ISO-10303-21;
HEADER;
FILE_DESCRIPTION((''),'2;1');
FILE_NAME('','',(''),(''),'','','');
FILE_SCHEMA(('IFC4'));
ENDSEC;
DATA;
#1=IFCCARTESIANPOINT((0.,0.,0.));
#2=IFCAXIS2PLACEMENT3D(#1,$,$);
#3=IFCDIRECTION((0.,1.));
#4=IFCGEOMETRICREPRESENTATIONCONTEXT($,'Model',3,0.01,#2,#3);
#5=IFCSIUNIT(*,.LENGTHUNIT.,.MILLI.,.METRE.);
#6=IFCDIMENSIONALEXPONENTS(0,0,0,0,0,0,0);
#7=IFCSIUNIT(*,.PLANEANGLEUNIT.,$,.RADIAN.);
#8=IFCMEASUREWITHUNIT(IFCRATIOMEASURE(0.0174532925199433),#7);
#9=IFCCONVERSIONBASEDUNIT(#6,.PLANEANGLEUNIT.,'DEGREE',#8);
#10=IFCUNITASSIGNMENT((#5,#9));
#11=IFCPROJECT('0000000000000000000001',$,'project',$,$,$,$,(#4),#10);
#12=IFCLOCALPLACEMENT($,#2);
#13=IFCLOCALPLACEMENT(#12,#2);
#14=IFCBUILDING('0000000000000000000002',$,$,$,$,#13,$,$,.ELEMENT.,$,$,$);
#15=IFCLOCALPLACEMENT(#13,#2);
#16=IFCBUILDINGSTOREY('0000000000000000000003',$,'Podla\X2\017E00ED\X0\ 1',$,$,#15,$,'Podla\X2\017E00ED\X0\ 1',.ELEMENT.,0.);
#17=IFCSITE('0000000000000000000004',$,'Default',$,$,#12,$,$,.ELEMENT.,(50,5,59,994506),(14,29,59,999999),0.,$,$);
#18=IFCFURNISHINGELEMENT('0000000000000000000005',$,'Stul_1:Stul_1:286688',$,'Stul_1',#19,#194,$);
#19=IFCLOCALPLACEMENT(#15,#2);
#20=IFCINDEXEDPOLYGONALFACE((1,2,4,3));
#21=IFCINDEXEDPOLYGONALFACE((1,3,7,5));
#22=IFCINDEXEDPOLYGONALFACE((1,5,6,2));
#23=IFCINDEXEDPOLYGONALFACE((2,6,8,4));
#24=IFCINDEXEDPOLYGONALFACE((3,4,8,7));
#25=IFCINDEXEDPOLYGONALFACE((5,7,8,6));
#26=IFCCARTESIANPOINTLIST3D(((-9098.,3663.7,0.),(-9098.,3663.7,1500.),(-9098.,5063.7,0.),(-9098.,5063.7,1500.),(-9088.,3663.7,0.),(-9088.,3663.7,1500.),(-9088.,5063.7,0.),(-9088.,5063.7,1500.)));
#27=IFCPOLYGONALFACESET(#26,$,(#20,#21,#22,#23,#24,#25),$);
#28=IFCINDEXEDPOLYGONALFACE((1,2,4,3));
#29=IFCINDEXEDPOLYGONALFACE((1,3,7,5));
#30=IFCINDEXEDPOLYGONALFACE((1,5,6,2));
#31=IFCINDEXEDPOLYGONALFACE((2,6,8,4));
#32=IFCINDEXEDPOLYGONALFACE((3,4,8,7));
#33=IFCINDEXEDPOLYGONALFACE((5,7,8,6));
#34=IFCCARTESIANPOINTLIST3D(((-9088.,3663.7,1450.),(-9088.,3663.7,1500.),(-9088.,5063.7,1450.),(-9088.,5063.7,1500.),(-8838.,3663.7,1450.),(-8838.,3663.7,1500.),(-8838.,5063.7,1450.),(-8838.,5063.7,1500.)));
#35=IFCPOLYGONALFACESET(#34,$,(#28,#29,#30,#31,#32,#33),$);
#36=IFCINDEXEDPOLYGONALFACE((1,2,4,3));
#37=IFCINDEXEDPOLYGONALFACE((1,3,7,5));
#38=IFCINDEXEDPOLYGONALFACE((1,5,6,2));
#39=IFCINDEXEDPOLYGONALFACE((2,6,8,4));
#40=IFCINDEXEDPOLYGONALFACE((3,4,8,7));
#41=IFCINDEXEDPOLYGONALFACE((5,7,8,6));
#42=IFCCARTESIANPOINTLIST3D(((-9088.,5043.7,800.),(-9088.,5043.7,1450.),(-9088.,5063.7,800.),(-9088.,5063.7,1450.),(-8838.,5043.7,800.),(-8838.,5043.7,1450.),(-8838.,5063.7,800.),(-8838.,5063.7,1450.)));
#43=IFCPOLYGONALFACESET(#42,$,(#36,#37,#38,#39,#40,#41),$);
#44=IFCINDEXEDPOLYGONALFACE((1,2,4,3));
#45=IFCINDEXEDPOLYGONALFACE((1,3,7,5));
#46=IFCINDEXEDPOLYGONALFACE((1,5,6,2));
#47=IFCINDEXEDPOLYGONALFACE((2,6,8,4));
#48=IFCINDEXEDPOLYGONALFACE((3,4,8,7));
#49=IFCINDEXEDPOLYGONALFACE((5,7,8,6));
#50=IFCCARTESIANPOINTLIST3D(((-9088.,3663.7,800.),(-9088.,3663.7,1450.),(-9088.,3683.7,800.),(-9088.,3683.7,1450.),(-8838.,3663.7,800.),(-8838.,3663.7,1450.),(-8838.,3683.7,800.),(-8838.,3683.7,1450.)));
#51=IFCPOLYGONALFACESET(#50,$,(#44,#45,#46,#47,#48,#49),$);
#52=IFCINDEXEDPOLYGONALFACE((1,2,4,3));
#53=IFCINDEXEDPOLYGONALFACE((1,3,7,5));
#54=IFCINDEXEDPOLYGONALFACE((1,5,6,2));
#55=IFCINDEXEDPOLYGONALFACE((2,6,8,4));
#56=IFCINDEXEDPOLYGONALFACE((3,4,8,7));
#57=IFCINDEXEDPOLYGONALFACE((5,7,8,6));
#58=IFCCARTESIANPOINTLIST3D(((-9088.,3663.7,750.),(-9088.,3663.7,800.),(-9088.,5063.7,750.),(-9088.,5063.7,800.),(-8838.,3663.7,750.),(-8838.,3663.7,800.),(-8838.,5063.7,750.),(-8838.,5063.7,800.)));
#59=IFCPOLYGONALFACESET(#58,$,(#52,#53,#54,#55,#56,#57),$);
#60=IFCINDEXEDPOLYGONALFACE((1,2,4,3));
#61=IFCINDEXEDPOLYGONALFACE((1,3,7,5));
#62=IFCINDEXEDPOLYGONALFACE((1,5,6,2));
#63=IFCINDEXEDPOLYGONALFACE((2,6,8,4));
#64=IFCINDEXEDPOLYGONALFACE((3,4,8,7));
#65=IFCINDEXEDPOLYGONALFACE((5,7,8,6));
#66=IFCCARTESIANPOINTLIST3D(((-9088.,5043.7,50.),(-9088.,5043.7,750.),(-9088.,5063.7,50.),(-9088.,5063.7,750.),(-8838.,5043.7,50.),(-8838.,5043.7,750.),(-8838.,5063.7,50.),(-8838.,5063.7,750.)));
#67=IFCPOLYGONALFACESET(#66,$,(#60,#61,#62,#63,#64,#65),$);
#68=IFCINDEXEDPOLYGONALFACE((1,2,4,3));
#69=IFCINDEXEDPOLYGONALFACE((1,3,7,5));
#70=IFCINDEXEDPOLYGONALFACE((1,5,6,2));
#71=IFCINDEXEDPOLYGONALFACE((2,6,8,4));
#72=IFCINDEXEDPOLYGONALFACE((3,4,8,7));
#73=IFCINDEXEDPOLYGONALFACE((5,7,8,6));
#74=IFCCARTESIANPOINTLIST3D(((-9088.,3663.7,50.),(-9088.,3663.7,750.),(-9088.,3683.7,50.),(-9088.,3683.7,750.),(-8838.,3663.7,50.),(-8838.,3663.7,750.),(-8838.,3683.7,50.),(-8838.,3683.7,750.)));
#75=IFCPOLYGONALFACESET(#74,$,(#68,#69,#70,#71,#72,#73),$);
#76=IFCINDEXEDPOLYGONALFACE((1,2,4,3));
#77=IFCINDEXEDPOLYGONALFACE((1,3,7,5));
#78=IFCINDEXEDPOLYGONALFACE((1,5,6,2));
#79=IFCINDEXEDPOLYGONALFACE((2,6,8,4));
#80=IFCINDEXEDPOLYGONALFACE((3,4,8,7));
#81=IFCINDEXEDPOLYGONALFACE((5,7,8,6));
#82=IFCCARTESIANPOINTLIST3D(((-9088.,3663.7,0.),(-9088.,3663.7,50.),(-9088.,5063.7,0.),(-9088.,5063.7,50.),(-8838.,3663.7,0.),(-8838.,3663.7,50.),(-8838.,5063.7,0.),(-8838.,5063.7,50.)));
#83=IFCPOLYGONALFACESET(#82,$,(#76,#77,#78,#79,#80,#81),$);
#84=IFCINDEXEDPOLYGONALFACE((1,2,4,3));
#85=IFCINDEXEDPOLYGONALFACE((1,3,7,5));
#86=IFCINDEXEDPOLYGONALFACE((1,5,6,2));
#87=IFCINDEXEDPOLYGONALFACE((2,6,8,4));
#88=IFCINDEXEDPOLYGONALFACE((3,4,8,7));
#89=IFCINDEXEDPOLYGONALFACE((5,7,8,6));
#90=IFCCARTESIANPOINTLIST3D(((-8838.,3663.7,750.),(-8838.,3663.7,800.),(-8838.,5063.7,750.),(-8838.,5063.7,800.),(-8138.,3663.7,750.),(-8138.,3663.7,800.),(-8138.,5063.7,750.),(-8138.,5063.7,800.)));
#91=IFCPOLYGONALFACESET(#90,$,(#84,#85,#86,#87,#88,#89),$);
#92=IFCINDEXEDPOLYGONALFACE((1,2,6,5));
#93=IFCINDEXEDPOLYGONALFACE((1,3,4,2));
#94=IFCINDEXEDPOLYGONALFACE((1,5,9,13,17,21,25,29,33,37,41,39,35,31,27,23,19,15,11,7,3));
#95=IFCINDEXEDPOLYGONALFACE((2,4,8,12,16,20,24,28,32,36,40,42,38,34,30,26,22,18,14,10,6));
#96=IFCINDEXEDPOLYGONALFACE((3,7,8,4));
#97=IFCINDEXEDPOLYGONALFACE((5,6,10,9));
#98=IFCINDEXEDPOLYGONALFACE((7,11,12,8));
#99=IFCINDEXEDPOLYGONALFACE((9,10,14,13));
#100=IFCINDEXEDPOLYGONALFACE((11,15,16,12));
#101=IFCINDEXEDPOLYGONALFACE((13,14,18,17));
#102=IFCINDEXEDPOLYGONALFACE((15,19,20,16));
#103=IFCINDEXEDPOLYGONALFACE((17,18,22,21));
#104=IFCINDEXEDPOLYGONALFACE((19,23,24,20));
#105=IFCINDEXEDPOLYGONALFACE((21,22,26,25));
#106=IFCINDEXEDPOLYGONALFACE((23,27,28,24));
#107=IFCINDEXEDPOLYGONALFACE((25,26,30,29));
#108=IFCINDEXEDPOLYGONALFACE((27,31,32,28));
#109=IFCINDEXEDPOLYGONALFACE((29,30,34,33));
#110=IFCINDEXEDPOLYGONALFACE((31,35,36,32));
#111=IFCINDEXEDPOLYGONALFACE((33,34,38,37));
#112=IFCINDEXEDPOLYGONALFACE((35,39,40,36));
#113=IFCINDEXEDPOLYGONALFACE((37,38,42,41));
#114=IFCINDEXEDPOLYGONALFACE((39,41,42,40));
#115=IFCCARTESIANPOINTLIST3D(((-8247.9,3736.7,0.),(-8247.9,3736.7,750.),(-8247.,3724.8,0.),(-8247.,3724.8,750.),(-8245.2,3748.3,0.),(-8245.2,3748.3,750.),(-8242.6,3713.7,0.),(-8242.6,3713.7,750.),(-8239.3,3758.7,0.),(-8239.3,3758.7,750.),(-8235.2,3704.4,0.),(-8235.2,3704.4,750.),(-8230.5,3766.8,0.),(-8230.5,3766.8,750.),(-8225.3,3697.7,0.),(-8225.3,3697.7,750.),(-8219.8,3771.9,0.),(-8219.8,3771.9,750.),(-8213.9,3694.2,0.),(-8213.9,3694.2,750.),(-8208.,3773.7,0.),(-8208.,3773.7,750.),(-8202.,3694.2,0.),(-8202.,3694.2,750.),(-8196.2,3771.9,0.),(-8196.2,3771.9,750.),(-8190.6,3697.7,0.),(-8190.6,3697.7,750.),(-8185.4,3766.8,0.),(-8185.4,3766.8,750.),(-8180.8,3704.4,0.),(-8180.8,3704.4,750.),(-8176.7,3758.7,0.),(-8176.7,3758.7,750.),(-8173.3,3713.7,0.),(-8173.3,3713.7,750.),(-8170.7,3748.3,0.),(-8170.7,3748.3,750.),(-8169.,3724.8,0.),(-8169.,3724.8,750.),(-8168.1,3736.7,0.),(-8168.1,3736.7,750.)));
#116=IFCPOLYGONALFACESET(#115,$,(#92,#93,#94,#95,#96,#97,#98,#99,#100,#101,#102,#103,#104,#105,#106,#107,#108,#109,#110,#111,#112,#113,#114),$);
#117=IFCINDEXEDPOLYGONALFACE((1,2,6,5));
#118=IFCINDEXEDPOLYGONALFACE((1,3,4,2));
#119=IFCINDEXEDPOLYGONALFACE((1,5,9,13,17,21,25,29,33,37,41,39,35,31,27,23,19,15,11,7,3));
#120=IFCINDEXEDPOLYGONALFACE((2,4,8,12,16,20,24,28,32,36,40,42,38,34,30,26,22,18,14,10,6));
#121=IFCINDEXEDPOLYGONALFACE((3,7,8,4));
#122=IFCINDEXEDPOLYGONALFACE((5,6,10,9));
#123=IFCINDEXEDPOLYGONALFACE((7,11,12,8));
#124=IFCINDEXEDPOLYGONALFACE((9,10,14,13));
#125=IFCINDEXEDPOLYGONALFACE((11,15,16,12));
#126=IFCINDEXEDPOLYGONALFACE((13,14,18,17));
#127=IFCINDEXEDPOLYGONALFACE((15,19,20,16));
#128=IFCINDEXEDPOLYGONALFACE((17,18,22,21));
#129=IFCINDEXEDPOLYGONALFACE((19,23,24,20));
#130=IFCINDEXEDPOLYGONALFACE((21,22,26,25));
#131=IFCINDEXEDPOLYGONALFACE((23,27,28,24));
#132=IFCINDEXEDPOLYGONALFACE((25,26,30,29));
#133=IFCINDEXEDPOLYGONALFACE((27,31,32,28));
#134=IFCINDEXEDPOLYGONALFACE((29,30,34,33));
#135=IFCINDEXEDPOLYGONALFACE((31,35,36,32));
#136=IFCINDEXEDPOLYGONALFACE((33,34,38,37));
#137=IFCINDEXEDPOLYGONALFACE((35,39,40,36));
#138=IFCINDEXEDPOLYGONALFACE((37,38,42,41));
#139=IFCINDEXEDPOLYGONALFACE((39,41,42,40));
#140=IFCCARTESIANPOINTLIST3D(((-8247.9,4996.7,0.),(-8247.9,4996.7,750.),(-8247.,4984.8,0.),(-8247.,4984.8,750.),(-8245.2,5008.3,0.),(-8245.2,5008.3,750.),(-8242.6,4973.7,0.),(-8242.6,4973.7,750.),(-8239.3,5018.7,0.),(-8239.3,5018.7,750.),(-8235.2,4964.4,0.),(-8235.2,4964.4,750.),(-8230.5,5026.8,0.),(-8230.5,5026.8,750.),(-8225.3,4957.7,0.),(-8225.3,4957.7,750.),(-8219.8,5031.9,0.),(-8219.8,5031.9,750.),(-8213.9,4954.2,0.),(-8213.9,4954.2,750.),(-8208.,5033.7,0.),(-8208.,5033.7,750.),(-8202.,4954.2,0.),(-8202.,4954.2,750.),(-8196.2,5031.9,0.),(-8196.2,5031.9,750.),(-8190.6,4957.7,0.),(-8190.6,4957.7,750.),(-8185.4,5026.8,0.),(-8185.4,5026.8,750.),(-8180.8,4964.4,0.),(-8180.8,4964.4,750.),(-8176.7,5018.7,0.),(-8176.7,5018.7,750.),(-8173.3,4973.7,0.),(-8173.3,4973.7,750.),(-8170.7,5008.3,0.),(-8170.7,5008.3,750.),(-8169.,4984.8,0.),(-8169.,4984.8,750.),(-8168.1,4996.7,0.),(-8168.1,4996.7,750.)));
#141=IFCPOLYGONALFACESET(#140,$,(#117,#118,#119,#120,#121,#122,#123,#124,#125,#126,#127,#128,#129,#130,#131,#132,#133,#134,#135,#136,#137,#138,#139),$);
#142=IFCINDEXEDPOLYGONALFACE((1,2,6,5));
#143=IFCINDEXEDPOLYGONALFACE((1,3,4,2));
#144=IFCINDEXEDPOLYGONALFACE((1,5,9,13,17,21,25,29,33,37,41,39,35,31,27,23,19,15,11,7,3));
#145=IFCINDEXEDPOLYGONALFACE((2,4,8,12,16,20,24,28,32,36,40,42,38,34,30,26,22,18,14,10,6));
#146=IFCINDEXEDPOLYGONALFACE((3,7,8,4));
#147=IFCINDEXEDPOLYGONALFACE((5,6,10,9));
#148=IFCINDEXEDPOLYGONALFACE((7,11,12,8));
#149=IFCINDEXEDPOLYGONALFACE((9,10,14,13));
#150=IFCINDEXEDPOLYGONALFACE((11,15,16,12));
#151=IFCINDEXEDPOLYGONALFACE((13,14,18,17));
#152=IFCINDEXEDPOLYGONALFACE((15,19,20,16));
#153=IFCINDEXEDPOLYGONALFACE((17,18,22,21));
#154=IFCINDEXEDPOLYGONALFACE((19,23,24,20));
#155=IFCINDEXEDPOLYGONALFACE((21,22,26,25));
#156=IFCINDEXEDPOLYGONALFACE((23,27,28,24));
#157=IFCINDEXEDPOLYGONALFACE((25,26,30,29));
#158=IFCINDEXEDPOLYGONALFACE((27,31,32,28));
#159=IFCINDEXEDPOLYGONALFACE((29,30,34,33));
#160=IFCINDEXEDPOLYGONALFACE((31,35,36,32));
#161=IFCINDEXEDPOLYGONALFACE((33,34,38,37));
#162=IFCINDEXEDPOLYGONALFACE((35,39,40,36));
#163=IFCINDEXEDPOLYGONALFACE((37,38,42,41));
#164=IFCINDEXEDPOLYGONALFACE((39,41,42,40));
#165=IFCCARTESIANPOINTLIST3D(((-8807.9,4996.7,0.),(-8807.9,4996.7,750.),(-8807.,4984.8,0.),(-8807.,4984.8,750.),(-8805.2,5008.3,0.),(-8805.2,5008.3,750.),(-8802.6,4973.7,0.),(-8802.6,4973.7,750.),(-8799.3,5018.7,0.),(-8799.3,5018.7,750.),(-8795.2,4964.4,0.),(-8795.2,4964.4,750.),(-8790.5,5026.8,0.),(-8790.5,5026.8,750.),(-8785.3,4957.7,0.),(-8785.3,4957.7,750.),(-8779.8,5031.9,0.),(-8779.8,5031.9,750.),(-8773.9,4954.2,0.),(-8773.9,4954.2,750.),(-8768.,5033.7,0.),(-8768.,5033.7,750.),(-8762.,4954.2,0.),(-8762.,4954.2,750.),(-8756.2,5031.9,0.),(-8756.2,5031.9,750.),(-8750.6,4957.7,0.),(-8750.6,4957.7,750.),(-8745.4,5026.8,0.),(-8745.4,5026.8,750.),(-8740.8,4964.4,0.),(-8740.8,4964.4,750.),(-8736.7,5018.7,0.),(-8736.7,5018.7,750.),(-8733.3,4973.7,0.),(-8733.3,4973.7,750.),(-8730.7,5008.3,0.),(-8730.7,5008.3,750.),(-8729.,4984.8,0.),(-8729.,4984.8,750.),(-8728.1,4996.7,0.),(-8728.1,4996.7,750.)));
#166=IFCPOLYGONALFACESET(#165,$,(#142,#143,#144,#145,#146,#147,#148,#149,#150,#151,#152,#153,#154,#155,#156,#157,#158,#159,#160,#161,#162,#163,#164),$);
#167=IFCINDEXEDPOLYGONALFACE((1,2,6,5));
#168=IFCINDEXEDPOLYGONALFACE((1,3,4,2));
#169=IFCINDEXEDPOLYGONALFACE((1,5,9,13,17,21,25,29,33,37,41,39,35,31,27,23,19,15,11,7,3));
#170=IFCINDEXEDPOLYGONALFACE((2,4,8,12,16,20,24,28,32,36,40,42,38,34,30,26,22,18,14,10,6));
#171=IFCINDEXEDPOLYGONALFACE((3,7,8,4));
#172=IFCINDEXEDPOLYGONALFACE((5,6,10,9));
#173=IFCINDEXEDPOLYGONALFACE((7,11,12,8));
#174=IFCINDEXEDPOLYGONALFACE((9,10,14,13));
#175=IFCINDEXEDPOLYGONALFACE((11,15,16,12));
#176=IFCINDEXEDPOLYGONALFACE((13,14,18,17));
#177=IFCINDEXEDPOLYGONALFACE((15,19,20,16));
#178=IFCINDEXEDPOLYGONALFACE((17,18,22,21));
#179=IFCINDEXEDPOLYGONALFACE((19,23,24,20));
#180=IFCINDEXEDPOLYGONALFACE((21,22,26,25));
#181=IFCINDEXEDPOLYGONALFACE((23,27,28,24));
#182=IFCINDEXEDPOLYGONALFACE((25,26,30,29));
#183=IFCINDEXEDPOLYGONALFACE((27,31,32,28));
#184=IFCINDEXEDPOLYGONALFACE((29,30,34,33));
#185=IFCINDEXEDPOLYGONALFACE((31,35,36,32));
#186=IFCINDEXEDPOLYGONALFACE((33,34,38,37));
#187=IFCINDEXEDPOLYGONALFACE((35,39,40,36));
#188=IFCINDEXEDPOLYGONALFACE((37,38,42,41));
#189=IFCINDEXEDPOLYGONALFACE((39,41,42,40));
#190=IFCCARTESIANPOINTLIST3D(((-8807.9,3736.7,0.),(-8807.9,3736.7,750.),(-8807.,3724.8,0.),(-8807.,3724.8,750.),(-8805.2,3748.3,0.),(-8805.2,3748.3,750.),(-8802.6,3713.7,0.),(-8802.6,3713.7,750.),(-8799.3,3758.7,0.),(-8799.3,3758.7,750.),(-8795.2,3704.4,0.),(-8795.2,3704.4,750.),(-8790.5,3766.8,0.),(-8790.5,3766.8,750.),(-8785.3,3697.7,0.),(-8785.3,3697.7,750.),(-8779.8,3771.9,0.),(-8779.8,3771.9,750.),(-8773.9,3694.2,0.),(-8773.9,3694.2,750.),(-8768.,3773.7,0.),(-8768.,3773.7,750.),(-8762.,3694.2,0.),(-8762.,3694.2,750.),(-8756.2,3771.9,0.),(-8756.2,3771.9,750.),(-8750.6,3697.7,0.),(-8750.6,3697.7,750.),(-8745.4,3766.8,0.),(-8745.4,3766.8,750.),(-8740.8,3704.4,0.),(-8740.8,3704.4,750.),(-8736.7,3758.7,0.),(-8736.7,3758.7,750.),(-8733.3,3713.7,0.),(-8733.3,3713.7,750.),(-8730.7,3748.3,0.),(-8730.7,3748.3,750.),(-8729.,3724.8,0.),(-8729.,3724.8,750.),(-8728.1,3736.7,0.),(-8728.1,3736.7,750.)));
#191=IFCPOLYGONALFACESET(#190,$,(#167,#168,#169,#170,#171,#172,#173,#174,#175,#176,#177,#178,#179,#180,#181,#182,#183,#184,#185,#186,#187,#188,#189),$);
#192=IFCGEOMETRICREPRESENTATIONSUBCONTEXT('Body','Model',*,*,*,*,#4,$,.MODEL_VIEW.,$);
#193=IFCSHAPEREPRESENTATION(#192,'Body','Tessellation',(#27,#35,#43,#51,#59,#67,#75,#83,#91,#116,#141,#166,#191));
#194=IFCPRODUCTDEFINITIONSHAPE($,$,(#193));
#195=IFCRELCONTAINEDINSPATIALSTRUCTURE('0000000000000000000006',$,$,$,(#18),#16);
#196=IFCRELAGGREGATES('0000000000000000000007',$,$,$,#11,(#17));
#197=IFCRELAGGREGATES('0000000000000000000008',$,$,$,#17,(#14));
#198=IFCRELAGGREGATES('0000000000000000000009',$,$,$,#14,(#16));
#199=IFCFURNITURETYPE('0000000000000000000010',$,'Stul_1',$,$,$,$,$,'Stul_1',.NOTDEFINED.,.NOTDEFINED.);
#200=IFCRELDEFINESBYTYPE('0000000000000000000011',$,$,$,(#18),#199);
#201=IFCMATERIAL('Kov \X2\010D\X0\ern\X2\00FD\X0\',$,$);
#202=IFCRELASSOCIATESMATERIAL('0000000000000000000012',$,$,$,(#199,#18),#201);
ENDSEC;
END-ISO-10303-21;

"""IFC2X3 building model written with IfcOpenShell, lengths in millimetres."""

from ifc_helpers import new_model, entity, si_unit, converted_unit, direction, frame, frame_2d, origin, origin_2d_with_axis, place, context, subcontext, project, spatial, rectangle, circle, extrude, source, transform, mapped, material, type_object, type_shapes, element, save


model = new_model("IFC2X3")

# Units and contexts
model_context = context("Model", 3, precision=0.01, world=origin(), true_north=direction((0.0, 1.0)))
body_context = subcontext(model_context, "Body", "Model", "MODEL_VIEW")
ifc_project = project(units=[si_unit("LENGTHUNIT", "METRE", prefix="MILLI"), converted_unit("PLANEANGLEUNIT", "DEGREE", entity("IfcRatioMeasure", 0.0174532925199433), si_unit("PLANEANGLEUNIT", "RADIAN"), dimensions=[0, 0, 0, 0, 0, 0, 0])], contexts=[model_context])

# Site, building, storey
site_placement = place(None, origin())
site = spatial("IfcSite", under=ifc_project, at=site_placement, Name="Default", CompositionType="ELEMENT", RefLatitude=(50, 5, 59, 994506), RefLongitude=(14, 29, 59, 999999), RefElevation=0.0)
building_placement = place(site_placement, origin())
building = spatial("IfcBuilding", under=site, at=building_placement, CompositionType="ELEMENT")
storey_placement = place(building_placement, origin())
storey = spatial("IfcBuildingStorey", under=building, at=storey_placement, Name="Podlaží 1", LongName="Podlaží 1", CompositionType="ELEMENT", Elevation=0.0)

# Furnishing element
ifc_material_1 = material(Name="Kov černý")
furniture_type = type_object("IfcFurnitureType", Name="Stul_1", ElementType="Stul_1", material=ifc_material_1)
shared_shape_1 = source(origin(), body_context, "Body", "SweptSolid", [
    extrude(rectangle(XDim=1400.0, YDim=10.0, at=origin_2d_with_axis()), frame((0.0, 605.0, 0.0), z_axis=(0.0, 0.0, 1.0), x_axis=(-1.0, 0.0, 0.0)), (0.0, 0.0, 1.0), 1500.0),
    extrude(rectangle(XDim=1400.0, YDim=250.0, at=frame_2d((0.0, 0.0), x_axis=(1.0, 0.0))), frame((0.0, 475.0, 1450.0), z_axis=(0.0, 0.0, 1.0), x_axis=(-1.0, 0.0, 0.0)), (0.0, 0.0, 1.0), 50.0),
    extrude(rectangle(XDim=20.0, YDim=250.0, at=origin_2d_with_axis()), frame((690.0, 475.0, 800.0), z_axis=(0.0, 0.0, 1.0), x_axis=(-1.0, 0.0, 0.0)), (0.0, 0.0, 1.0), 650.0),
    extrude(rectangle(XDim=20.0, YDim=250.0, at=frame_2d((0.0, 0.0), x_axis=(1.0, 0.0))), frame((-690.0, 475.0, 800.0), z_axis=(0.0, 0.0, 1.0), x_axis=(-1.0, 0.0, 0.0)), (0.0, 0.0, 1.0), 650.0),
    extrude(rectangle(XDim=1400.0, YDim=250.0, at=origin_2d_with_axis()), frame((0.0, 475.0, 750.0), z_axis=(0.0, 0.0, 1.0), x_axis=(-1.0, 0.0, 0.0)), (0.0, 0.0, 1.0), 50.0),
    extrude(rectangle(XDim=20.0, YDim=250.0, at=origin_2d_with_axis()), frame((690.0, 475.0, 50.0), z_axis=(0.0, 0.0, 1.0), x_axis=(-1.0, 0.0, 0.0)), (0.0, 0.0, 1.0), 700.0),
    extrude(rectangle(XDim=20.0, YDim=250.0, at=frame_2d((0.0, 0.0), x_axis=(1.0, 0.0))), frame((-690.0, 475.0, 50.0), z_axis=(0.0, 0.0, 1.0), x_axis=(-1.0, 0.0, 0.0)), (0.0, 0.0, 1.0), 700.0),
    extrude(rectangle(XDim=1400.0, YDim=250.0, at=origin_2d_with_axis()), frame((0.0, 475.0, 0.0), z_axis=(0.0, 0.0, 1.0), x_axis=(-1.0, 0.0, 0.0)), (0.0, 0.0, 1.0), 50.0),
    extrude(rectangle(XDim=1400.0, YDim=700.0, at=origin_2d_with_axis()), frame((0.0, 0.0, 750.0), z_axis=(0.0, 0.0, 1.0), x_axis=(-1.0, 0.0, 0.0)), (0.0, 0.0, 1.0), 50.0),
    extrude(circle(Radius=40.0, at=frame_2d((0.0, 0.0), x_axis=(1.0, 0.0))), frame((-630.0, -280.0, 0.0)), (0.0, 0.0, 1.0), 750.0),
    extrude(circle(Radius=40.0, at=frame_2d((0.0, 0.0), x_axis=(1.0, 0.0))), frame((630.0, -280.0, 0.0)), (0.0, 0.0, 1.0), 750.0),
    extrude(circle(Radius=40.0, at=frame_2d((0.0, 0.0), x_axis=(1.0, 0.0))), frame((630.0, 280.0, 0.0)), (0.0, 0.0, 1.0), 750.0),
    extrude(circle(Radius=40.0, at=frame_2d((0.0, 0.0), x_axis=(1.0, 0.0))), frame((-630.0, 280.0, 0.0)), (0.0, 0.0, 1.0), 750.0),
])
type_shapes(furniture_type, [shared_shape_1])
for number, where, z_axis, x_axis, name in (
    (1, (-8488.0, 4363.7, 0.0), (0.0, 0.0, 1.0), (0.0, 1.0, 0.0), "Stul_1:Stul_1:286688"),
):
    element("IfcFurnishingElement", number, at=place(storey_placement, frame(where, z_axis=z_axis, x_axis=x_axis)), inside=storey, type_object=furniture_type, material=ifc_material_1, Name=name, ObjectType="Stul_1", context=body_context, shape_type="MappedRepresentation", body=[
        mapped(shared_shape_1, transform((0.0, 0.0, 0.0), scale=1.0)),
    ])

save(model, "model.ifc")
